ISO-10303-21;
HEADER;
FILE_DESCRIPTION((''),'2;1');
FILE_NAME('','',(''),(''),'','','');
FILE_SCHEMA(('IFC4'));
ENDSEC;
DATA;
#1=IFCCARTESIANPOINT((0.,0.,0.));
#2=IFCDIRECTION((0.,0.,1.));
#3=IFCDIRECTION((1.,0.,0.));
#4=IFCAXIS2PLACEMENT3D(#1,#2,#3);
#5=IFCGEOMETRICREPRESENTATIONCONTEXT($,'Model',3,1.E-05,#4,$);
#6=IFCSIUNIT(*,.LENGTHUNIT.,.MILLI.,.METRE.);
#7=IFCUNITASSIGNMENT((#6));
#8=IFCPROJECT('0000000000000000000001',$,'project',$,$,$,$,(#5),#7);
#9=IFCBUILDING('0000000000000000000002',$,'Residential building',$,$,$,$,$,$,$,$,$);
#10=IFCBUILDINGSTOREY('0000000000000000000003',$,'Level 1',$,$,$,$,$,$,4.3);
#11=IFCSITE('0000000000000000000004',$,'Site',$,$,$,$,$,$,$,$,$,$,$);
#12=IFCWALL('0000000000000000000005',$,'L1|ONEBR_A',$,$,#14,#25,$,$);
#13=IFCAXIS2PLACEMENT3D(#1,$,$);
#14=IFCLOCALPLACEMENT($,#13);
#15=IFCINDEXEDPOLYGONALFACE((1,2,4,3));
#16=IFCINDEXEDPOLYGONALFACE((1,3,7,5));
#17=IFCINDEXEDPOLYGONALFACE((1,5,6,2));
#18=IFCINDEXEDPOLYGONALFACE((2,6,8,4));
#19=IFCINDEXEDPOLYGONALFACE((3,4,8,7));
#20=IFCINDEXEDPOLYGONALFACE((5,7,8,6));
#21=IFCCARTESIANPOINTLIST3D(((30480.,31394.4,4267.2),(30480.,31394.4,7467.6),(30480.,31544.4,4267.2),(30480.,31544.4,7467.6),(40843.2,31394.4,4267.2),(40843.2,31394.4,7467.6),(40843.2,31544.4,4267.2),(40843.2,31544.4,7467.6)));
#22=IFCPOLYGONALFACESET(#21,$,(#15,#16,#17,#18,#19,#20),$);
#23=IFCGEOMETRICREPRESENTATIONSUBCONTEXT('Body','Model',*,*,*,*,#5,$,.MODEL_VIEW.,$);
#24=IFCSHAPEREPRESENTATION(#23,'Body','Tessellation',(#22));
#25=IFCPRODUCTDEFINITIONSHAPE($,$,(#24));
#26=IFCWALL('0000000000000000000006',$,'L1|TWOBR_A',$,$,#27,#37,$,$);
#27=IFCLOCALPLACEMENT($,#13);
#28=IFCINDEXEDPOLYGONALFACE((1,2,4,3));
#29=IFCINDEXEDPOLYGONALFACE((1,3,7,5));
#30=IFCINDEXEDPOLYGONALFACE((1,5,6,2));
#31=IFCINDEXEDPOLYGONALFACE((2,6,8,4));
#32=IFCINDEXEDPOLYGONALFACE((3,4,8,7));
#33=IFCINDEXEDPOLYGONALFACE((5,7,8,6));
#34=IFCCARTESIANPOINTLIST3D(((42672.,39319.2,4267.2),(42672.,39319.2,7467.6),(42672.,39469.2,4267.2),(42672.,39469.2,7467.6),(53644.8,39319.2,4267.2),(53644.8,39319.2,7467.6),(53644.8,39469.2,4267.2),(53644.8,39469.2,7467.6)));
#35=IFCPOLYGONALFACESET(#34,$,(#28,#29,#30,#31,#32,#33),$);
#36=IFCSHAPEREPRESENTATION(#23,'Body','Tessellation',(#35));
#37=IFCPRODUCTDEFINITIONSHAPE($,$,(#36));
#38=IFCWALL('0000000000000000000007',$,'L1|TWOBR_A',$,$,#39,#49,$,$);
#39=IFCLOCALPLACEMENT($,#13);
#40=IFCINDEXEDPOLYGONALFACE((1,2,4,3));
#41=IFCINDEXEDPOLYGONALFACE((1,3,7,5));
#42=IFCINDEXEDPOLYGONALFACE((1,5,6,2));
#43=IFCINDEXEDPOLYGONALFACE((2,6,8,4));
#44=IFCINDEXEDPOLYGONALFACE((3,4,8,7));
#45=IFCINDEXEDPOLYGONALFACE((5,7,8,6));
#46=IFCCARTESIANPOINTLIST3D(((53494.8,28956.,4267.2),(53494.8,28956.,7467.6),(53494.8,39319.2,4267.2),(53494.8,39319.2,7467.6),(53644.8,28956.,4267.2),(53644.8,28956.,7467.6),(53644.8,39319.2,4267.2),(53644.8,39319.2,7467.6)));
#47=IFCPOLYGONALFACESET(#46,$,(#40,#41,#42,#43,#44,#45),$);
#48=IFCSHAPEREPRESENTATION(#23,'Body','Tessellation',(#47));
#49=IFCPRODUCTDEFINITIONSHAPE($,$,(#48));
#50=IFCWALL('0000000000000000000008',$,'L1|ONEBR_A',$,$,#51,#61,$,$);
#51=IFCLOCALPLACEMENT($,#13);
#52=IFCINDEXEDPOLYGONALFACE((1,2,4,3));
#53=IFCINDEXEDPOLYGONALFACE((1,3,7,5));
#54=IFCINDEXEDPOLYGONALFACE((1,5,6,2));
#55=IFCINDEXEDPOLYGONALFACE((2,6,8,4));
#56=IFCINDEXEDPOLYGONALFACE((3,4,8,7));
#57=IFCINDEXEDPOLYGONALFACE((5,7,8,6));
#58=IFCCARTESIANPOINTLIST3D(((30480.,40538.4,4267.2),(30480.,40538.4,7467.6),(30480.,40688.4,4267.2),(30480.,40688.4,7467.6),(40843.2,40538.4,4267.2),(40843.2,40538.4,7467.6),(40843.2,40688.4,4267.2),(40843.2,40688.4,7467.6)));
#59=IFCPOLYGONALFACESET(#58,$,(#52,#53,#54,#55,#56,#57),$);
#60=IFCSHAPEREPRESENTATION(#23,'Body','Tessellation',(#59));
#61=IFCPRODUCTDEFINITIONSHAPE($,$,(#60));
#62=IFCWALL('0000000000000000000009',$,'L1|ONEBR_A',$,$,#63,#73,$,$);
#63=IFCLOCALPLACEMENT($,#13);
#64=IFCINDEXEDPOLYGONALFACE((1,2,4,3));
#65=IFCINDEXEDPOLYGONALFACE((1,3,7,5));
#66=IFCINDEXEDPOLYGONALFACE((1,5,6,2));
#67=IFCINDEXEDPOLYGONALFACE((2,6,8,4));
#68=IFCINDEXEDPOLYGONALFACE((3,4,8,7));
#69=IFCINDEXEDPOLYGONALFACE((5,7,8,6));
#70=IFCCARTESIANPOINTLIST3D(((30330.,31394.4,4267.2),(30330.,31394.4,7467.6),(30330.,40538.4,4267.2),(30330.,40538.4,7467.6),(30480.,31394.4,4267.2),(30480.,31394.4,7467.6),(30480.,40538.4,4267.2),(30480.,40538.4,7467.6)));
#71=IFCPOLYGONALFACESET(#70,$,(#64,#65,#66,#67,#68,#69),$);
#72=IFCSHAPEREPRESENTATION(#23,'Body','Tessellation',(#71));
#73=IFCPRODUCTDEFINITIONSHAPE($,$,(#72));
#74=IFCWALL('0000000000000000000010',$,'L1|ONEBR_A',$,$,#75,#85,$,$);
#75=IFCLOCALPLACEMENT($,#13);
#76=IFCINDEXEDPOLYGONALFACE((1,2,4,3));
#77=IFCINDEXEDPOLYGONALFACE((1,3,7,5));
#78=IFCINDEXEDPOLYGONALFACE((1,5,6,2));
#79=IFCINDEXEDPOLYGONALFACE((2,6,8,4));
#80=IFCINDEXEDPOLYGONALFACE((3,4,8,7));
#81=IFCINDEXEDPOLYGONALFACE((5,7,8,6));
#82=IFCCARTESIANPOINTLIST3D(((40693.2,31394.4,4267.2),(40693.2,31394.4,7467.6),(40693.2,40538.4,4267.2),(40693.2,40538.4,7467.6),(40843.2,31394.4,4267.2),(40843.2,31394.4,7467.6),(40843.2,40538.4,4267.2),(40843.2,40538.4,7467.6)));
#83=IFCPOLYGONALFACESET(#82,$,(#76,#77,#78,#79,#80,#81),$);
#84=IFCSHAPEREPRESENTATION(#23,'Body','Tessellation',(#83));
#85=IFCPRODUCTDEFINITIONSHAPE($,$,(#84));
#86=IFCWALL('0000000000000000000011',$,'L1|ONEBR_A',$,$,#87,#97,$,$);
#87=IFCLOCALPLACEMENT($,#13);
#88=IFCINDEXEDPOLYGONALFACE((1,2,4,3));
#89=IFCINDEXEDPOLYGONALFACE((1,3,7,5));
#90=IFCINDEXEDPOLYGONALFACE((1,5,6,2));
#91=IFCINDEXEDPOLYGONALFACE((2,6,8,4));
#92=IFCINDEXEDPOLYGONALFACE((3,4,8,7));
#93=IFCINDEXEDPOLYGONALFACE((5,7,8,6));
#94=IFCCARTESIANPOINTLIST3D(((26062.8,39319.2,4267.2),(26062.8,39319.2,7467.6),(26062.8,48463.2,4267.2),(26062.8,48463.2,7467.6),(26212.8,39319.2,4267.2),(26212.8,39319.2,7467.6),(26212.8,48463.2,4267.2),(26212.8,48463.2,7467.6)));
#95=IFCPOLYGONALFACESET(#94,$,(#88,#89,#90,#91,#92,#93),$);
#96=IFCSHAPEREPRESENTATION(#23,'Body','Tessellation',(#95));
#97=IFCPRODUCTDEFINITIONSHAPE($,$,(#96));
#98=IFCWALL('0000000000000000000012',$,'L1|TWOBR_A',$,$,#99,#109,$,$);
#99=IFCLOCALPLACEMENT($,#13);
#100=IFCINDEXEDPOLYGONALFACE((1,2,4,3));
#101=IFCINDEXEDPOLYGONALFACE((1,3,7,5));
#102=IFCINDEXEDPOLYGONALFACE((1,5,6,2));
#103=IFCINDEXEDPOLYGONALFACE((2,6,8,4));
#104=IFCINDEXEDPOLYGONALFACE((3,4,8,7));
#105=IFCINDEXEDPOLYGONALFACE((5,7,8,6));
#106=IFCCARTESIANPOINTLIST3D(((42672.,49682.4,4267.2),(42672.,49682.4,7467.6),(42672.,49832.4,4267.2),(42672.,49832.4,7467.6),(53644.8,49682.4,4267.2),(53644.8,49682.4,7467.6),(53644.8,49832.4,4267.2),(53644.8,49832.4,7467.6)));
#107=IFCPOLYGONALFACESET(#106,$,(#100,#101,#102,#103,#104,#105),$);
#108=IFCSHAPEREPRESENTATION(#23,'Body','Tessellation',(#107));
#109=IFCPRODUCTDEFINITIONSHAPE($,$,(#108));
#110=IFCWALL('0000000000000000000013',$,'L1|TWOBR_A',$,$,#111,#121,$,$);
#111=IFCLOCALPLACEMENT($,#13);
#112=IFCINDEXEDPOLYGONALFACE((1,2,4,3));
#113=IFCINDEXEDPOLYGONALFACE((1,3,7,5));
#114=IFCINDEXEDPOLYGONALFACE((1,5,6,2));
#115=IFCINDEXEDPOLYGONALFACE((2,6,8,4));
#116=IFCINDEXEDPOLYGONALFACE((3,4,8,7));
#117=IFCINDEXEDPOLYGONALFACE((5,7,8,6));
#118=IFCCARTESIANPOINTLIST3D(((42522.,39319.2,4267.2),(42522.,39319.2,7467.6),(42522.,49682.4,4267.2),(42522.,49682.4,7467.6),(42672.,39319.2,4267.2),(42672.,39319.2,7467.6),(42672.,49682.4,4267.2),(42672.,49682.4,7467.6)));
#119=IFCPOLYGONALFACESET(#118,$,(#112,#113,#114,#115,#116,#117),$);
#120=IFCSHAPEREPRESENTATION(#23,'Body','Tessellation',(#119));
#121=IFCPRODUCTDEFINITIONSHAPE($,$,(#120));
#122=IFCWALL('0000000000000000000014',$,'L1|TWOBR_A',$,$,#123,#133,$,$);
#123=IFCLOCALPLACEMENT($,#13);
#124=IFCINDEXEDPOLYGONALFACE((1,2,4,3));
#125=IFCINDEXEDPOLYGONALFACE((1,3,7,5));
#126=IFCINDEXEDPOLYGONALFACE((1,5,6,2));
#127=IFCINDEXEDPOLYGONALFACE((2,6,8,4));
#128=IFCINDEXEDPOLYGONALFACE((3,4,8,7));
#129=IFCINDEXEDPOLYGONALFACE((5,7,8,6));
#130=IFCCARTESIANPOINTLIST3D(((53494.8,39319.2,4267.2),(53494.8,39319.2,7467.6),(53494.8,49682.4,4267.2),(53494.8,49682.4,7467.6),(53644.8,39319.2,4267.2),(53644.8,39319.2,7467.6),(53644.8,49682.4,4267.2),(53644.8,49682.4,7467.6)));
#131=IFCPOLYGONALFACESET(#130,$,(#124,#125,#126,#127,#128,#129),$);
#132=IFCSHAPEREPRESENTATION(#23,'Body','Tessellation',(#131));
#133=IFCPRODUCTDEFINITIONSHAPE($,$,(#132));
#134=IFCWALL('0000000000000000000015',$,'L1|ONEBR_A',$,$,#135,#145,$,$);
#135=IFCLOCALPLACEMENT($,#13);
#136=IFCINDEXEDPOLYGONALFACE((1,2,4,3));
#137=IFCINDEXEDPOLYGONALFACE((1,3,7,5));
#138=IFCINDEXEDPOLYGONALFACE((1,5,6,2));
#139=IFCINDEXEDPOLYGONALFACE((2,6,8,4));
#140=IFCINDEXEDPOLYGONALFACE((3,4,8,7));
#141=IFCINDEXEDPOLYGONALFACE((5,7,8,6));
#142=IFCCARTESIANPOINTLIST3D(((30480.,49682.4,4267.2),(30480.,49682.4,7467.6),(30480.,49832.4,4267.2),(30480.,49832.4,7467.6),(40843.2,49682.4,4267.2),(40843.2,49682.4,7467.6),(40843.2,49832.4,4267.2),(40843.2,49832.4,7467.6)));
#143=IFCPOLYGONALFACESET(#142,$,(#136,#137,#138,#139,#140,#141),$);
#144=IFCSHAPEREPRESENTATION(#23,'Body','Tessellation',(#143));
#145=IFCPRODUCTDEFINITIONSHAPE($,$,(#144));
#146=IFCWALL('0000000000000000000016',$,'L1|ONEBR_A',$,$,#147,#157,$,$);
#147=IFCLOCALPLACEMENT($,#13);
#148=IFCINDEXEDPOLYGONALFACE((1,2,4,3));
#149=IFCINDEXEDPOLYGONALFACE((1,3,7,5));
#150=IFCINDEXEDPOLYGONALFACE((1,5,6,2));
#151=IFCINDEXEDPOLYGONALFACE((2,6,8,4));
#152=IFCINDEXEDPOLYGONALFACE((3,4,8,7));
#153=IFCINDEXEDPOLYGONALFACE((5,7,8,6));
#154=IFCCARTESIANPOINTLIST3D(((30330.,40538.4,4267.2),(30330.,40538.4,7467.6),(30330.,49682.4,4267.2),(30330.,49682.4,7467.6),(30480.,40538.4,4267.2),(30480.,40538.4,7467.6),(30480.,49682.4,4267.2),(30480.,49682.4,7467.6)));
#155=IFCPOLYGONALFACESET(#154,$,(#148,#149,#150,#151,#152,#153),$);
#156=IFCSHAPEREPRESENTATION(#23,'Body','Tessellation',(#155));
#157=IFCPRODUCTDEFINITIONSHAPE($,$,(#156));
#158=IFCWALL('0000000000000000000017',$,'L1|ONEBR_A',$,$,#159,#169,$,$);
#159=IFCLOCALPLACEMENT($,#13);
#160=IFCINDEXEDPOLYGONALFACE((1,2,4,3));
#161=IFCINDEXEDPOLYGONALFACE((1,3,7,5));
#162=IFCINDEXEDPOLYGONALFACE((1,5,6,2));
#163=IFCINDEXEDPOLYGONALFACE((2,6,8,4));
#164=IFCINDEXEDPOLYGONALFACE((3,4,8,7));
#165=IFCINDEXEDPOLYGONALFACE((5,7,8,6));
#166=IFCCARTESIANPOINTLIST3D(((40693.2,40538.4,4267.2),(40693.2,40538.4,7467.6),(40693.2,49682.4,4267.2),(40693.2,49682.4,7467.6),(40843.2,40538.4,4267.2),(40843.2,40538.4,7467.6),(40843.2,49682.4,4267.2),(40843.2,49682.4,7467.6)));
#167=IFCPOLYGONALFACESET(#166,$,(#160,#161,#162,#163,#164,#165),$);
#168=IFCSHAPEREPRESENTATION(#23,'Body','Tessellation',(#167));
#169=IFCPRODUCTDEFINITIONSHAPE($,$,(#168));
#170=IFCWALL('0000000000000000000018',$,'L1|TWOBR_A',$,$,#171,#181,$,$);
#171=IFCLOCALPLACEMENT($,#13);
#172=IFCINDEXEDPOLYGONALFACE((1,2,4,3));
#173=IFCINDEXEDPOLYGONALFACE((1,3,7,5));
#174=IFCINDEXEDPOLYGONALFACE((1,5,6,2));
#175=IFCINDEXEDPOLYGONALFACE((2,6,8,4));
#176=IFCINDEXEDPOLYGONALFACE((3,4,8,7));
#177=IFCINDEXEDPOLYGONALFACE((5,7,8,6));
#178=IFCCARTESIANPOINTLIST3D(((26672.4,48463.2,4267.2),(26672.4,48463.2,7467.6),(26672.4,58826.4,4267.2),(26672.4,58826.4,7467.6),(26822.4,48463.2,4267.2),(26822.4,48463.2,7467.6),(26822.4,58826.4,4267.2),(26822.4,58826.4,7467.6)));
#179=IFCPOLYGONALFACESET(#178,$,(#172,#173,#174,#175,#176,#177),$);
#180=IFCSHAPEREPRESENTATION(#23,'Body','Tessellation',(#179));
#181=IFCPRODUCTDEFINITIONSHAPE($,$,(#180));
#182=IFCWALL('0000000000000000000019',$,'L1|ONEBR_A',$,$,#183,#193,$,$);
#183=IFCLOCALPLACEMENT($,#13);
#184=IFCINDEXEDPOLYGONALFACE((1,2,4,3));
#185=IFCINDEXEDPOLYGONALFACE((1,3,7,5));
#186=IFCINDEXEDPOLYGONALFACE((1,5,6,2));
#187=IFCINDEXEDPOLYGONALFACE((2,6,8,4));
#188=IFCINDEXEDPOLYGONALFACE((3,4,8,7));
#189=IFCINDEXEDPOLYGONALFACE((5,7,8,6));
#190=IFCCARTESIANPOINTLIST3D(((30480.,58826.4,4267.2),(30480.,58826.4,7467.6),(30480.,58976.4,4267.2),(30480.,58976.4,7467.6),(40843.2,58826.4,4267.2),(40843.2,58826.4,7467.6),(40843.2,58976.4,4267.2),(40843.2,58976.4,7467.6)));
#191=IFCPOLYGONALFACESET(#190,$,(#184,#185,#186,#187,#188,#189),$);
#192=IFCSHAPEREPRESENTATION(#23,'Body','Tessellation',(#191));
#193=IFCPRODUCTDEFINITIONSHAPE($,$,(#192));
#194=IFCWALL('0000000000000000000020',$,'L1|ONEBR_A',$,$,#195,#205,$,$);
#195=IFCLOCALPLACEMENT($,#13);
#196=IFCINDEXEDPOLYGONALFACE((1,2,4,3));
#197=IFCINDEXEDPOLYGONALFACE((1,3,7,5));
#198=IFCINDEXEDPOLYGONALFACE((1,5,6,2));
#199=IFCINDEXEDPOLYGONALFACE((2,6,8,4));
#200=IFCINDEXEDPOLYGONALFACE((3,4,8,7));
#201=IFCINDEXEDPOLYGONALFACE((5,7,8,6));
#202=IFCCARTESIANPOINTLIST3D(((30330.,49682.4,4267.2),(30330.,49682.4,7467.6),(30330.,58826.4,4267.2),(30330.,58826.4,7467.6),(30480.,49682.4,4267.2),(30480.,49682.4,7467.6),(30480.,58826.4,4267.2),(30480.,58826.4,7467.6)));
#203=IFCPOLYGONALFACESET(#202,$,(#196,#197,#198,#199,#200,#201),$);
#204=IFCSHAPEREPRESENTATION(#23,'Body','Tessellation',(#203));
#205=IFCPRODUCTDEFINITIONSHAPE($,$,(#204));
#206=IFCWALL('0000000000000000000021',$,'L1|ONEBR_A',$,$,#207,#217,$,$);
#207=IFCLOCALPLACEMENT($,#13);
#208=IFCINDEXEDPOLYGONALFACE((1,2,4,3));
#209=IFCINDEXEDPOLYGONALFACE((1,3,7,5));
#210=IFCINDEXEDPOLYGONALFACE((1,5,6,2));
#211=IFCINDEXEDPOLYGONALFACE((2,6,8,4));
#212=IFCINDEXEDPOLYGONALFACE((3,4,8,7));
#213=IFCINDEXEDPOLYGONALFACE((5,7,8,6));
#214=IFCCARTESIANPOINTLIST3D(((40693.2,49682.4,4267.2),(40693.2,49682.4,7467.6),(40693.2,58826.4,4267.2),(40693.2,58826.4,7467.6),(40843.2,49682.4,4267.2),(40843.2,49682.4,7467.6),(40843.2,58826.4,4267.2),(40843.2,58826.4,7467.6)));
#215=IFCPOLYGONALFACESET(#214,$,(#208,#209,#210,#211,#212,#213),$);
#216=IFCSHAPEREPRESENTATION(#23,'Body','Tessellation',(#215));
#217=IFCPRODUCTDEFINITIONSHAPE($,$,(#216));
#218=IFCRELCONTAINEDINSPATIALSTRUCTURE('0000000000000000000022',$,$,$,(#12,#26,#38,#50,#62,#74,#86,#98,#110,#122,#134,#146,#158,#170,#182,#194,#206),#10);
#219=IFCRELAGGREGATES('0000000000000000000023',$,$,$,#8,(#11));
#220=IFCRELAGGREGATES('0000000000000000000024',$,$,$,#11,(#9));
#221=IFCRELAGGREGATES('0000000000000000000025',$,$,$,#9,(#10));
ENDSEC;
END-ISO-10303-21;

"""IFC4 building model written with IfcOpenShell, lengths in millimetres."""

from ifc_helpers import new_model, si_unit, frame, origin_with_axes, place, context, subcontext, project, spatial, indexed_curve, outline, extrude, element, save


model = new_model("IFC4")

# Units and contexts
model_context = context("Model", 3, precision=1e-05, world=origin_with_axes())
body_context = subcontext(model_context, "Body", "Model", "MODEL_VIEW")
ifc_project = project(units=[si_unit("LENGTHUNIT", "METRE", prefix="MILLI")], contexts=[model_context])

# Site, building, storey
site = spatial("IfcSite", under=ifc_project, Name="Site")
building = spatial("IfcBuilding", under=site, Name="Residential building")
storey = spatial("IfcBuildingStorey", under=building, Name="Level 1", Elevation=4.3)

# Walls
wall_1_placement = place(None, frame((30480.0, 31394.4, 4267.2), z_axis=(0.0, 0.0, 1.0), x_axis=(1.0, 0.0, 0.0)))
element("IfcWall", 1, at=wall_1_placement, inside=storey, Name="L1|ONEBR_A", context=body_context, shape_type="SweptSolid", body=[
    extrude(outline(indexed_curve([(0.0, 0.0), (0.0, 150.0), (10363.2, 150.0), (10363.2, 0.0), (0.0, 0.0)], self_intersect=False)), origin_with_axes(), (0.0, 0.0, 1.0), 3200.4),
])
wall_2_placement = place(None, frame((42672.0, 39319.2, 4267.2), z_axis=(0.0, 0.0, 1.0), x_axis=(1.0, 0.0, 0.0)))
element("IfcWall", 2, at=wall_2_placement, inside=storey, Name="L1|TWOBR_A", context=body_context, shape_type="SweptSolid", body=[
    extrude(outline(indexed_curve([(0.0, 0.0), (0.0, 150.0), (10972.8, 150.0), (10972.8, 0.0), (0.0, 0.0)], self_intersect=False)), origin_with_axes(), (0.0, 0.0, 1.0), 3200.4),
])
for number, where, z_axis, x_axis, name in (
    (3, (53644.8, 28956.0, 4267.2), (0.0, 0.0, 1.0), (0.0, 1.0, 0.0), "L1|TWOBR_A"),
    (4, (30480.0, 40538.4, 4267.2), (0.0, 0.0, 1.0), (1.0, 0.0, 0.0), "L1|ONEBR_A"),
):
    element("IfcWall", number, at=place(None, frame(where, z_axis=z_axis, x_axis=x_axis)), inside=storey, Name=name, context=body_context, shape_type="SweptSolid", body=[
        extrude(outline(indexed_curve([(0.0, 0.0), (0.0, 150.0), (10363.2, 150.0), (10363.2, 0.0), (0.0, 0.0)], self_intersect=False)), origin_with_axes(), (0.0, 0.0, 1.0), 3200.4),
    ])
for number, where, z_axis, x_axis, name in (
    (5, (30480.0, 31394.4, 4267.2), (0.0, 0.0, 1.0), (0.0, 1.0, 0.0), "L1|ONEBR_A"),
    (6, (40843.2, 31394.4, 4267.2), (0.0, 0.0, 1.0), (0.0, 1.0, 0.0), "L1|ONEBR_A"),
    (7, (26212.8, 39319.2, 4267.2), (0.0, 0.0, 1.0), (0.0, 1.0, 0.0), "L1|ONEBR_A"),
):
    element("IfcWall", number, at=place(None, frame(where, z_axis=z_axis, x_axis=x_axis)), inside=storey, Name=name, context=body_context, shape_type="SweptSolid", body=[
        extrude(outline(indexed_curve([(0.0, 0.0), (0.0, 150.0), (9144.0, 150.0), (9144.0, 0.0), (0.0, 0.0)], self_intersect=False)), origin_with_axes(), (0.0, 0.0, 1.0), 3200.4),
    ])
for number, where, z_axis, x_axis, name in (
    (8, (42672.0, 49682.4, 4267.2), (0.0, 0.0, 1.0), (1.0, 0.0, 0.0), "L1|TWOBR_A"),
):
    element("IfcWall", number, at=place(None, frame(where, z_axis=z_axis, x_axis=x_axis)), inside=storey, Name=name, context=body_context, shape_type="SweptSolid", body=[
        extrude(outline(indexed_curve([(0.0, 0.0), (0.0, 150.0), (10972.8, 150.0), (10972.8, 0.0), (0.0, 0.0)], self_intersect=False)), origin_with_axes(), (0.0, 0.0, 1.0), 3200.4),
    ])
for number, where, z_axis, x_axis, name in (
    (9, (42672.0, 39319.2, 4267.2), (0.0, 0.0, 1.0), (0.0, 1.0, 0.0), "L1|TWOBR_A"),
    (10, (53644.8, 39319.2, 4267.2), (0.0, 0.0, 1.0), (0.0, 1.0, 0.0), "L1|TWOBR_A"),
    (11, (30480.0, 49682.4, 4267.2), (0.0, 0.0, 1.0), (1.0, 0.0, 0.0), "L1|ONEBR_A"),
):
    element("IfcWall", number, at=place(None, frame(where, z_axis=z_axis, x_axis=x_axis)), inside=storey, Name=name, context=body_context, shape_type="SweptSolid", body=[
        extrude(outline(indexed_curve([(0.0, 0.0), (0.0, 150.0), (10363.2, 150.0), (10363.2, 0.0), (0.0, 0.0)], self_intersect=False)), origin_with_axes(), (0.0, 0.0, 1.0), 3200.4),
    ])
for number, where, z_axis, x_axis, name in (
    (12, (30480.0, 40538.4, 4267.2), (0.0, 0.0, 1.0), (0.0, 1.0, 0.0), "L1|ONEBR_A"),
    (13, (40843.2, 40538.4, 4267.2), (0.0, 0.0, 1.0), (0.0, 1.0, 0.0), "L1|ONEBR_A"),
):
    element("IfcWall", number, at=place(None, frame(where, z_axis=z_axis, x_axis=x_axis)), inside=storey, Name=name, context=body_context, shape_type="SweptSolid", body=[
        extrude(outline(indexed_curve([(0.0, 0.0), (0.0, 150.0), (9144.0, 150.0), (9144.0, 0.0), (0.0, 0.0)], self_intersect=False)), origin_with_axes(), (0.0, 0.0, 1.0), 3200.4),
    ])
for number, where, z_axis, x_axis, name in (
    (14, (26822.4, 48463.2, 4267.2), (0.0, 0.0, 1.0), (0.0, 1.0, 0.0), "L1|TWOBR_A"),
    (15, (30480.0, 58826.4, 4267.2), (0.0, 0.0, 1.0), (1.0, 0.0, 0.0), "L1|ONEBR_A"),
):
    element("IfcWall", number, at=place(None, frame(where, z_axis=z_axis, x_axis=x_axis)), inside=storey, Name=name, context=body_context, shape_type="SweptSolid", body=[
        extrude(outline(indexed_curve([(0.0, 0.0), (0.0, 150.0), (10363.2, 150.0), (10363.2, 0.0), (0.0, 0.0)], self_intersect=False)), origin_with_axes(), (0.0, 0.0, 1.0), 3200.4),
    ])
for number, where, z_axis, x_axis, name in (
    (16, (30480.0, 49682.4, 4267.2), (0.0, 0.0, 1.0), (0.0, 1.0, 0.0), "L1|ONEBR_A"),
    (17, (40843.2, 49682.4, 4267.2), (0.0, 0.0, 1.0), (0.0, 1.0, 0.0), "L1|ONEBR_A"),
):
    element("IfcWall", number, at=place(None, frame(where, z_axis=z_axis, x_axis=x_axis)), inside=storey, Name=name, context=body_context, shape_type="SweptSolid", body=[
        extrude(outline(indexed_curve([(0.0, 0.0), (0.0, 150.0), (9144.0, 150.0), (9144.0, 0.0), (0.0, 0.0)], self_intersect=False)), origin_with_axes(), (0.0, 0.0, 1.0), 3200.4),
    ])

save(model, "model.ifc")
